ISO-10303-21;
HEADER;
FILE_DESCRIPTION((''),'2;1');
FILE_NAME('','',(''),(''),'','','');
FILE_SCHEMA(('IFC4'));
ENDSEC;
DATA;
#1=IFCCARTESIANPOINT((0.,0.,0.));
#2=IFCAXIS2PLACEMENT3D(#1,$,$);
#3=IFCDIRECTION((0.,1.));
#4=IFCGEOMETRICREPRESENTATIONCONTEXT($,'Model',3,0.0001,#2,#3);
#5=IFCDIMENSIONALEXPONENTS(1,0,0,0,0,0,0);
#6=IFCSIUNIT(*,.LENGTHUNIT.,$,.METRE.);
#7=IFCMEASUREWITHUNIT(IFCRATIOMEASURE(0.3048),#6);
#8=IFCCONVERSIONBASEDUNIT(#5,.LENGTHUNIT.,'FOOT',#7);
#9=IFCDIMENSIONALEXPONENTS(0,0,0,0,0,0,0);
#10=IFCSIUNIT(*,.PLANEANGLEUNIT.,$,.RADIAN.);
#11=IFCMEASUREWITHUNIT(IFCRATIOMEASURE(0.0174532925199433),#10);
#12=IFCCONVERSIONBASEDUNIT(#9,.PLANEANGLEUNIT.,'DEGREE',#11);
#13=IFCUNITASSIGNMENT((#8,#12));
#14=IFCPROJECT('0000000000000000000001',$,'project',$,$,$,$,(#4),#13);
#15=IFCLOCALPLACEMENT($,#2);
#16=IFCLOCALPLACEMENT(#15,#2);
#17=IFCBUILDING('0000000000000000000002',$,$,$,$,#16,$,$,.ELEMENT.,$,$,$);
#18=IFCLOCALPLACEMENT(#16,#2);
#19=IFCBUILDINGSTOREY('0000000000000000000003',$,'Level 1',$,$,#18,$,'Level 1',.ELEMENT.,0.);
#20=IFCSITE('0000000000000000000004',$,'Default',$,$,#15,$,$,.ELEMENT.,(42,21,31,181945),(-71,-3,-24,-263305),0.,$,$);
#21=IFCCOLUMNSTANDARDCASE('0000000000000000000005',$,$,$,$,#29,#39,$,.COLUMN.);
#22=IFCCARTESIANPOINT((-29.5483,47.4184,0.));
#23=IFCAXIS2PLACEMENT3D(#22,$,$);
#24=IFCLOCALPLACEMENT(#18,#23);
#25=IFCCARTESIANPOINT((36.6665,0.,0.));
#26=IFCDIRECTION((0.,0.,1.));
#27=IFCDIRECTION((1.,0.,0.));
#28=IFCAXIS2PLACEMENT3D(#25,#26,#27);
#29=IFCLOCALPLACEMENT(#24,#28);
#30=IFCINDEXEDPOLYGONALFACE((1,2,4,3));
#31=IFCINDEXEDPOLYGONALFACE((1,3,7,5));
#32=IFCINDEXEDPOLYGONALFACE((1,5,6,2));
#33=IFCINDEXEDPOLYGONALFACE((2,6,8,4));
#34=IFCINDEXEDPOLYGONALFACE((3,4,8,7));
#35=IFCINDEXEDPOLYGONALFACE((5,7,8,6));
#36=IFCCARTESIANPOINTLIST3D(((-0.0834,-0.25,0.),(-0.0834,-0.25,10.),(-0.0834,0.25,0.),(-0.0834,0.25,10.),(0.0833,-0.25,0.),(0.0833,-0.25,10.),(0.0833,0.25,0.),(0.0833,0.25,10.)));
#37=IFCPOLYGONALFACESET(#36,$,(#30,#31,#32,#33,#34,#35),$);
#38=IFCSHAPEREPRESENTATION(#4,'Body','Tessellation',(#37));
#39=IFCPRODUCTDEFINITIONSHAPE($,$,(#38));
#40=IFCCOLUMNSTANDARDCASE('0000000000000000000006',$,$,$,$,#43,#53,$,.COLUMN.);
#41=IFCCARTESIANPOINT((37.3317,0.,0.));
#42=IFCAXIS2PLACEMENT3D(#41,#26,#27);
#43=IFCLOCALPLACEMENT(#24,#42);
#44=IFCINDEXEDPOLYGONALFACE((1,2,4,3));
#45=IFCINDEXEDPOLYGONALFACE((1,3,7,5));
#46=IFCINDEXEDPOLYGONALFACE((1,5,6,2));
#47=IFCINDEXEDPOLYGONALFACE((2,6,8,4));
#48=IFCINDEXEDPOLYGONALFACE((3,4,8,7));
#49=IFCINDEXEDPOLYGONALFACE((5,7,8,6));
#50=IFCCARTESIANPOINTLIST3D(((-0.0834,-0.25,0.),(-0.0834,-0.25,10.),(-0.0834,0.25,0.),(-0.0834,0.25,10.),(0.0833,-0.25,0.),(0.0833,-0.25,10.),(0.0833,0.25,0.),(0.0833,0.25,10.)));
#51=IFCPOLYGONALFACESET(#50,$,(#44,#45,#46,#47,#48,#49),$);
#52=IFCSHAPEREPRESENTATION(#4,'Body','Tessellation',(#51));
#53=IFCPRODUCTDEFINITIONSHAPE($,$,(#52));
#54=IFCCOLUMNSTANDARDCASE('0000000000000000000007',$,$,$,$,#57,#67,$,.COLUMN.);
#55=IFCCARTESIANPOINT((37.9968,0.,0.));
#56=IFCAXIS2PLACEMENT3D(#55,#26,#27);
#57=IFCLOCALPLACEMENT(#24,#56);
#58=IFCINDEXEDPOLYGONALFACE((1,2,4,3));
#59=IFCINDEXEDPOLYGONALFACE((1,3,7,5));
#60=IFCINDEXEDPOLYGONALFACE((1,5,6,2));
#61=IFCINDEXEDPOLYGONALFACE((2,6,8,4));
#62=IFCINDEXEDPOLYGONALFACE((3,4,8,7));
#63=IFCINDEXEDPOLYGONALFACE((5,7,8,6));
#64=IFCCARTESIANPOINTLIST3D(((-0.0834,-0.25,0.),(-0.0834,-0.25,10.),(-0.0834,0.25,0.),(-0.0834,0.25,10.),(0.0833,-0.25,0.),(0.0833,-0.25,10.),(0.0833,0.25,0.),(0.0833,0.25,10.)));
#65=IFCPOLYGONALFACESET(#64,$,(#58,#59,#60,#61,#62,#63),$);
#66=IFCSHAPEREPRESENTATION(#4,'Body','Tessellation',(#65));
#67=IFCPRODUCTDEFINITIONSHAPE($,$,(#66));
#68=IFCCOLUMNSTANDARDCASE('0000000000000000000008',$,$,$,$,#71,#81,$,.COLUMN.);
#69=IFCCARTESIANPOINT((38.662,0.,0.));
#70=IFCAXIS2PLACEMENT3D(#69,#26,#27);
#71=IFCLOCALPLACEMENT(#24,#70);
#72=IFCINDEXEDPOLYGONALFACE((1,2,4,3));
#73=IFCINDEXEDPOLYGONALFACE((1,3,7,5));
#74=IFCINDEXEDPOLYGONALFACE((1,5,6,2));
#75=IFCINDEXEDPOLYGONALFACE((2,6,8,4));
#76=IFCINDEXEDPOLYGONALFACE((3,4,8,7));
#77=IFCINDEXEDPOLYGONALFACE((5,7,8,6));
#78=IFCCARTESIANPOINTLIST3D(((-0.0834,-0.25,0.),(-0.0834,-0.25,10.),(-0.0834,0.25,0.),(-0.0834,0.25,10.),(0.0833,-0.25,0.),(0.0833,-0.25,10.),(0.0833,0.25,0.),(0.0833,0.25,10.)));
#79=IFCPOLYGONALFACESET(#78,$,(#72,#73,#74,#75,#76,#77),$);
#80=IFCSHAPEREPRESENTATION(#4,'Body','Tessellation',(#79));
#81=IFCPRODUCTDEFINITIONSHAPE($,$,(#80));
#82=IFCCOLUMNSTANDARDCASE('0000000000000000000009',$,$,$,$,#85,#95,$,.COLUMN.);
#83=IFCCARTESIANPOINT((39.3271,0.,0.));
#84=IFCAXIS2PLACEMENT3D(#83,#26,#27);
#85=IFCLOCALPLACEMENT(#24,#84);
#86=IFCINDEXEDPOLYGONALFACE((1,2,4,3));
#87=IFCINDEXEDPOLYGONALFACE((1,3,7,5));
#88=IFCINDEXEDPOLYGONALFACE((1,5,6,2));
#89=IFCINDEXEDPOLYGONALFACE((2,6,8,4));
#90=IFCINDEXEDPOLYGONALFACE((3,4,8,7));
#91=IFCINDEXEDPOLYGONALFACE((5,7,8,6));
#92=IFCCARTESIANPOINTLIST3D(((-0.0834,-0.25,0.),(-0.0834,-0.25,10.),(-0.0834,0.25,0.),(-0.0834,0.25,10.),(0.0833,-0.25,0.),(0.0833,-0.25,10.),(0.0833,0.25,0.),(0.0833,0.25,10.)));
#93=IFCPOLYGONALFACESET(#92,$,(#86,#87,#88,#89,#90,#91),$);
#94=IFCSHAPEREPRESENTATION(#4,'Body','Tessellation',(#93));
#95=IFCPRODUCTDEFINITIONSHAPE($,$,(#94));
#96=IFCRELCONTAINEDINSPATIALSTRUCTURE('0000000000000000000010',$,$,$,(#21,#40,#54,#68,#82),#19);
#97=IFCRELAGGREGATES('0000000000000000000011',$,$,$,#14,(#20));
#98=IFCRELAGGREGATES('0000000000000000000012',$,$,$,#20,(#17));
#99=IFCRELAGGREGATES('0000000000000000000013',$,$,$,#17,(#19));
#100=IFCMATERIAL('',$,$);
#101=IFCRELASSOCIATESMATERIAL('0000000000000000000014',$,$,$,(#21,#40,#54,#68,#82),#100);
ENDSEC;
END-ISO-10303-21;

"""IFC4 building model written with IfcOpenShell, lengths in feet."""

from ifc_helpers import new_model, entity, si_unit, converted_unit, direction, frame, origin, place, context, project, spatial, rectangle, extrude, material, element, save


model = new_model("IFC4")

# Units and contexts
model_context = context("Model", 3, precision=0.0001, world=origin(), true_north=direction((0.0, 1.0)))
ifc_project = project(units=[converted_unit("LENGTHUNIT", "FOOT", entity("IfcRatioMeasure", 0.3048), si_unit("LENGTHUNIT", "METRE"), dimensions=[1, 0, 0, 0, 0, 0, 0]), converted_unit("PLANEANGLEUNIT", "DEGREE", entity("IfcRatioMeasure", 0.0174532925199433), si_unit("PLANEANGLEUNIT", "RADIAN"), dimensions=[0, 0, 0, 0, 0, 0, 0])], contexts=[model_context])

# Site, building, storey
site_placement = place(None, origin())
site = spatial("IfcSite", under=ifc_project, at=site_placement, Name="Default", CompositionType="ELEMENT", RefLatitude=(42, 21, 31, 181945), RefLongitude=(-71, -3, -24, -263305), RefElevation=0.0)
building_placement = place(site_placement, origin())
building = spatial("IfcBuilding", under=site, at=building_placement, CompositionType="ELEMENT")
storey_placement = place(building_placement, origin())
storey = spatial("IfcBuildingStorey", under=building, at=storey_placement, Name="Level 1", LongName="Level 1", CompositionType="ELEMENT", Elevation=0.0)

# Columns
ifc_material = material(Name="")
placement = place(storey_placement, frame((-29.5483, 47.4184, 0.0)))
for number, where, z_axis, x_axis in (
    (1, (36.6665, 0.0, 0.0), (0.0, 0.0, 1.0), (1.0, 0.0, 0.0)),
    (2, (37.3317, 0.0, 0.0), (0.0, 0.0, 1.0), (1.0, 0.0, 0.0)),
    (3, (37.9968, 0.0, 0.0), (0.0, 0.0, 1.0), (1.0, 0.0, 0.0)),
    (4, (38.662, 0.0, 0.0), (0.0, 0.0, 1.0), (1.0, 0.0, 0.0)),
    (5, (39.3271, 0.0, 0.0), (0.0, 0.0, 1.0), (1.0, 0.0, 0.0)),
):
    element("IfcColumnStandardCase", number, at=place(placement, frame(where, z_axis=z_axis, x_axis=x_axis)), inside=storey, material=ifc_material, PredefinedType="COLUMN", context=model_context, shape_type="SweptSolid", body=[
        extrude(rectangle(XDim=0.1667, YDim=0.5), origin(), (0.0, 0.0, 1.0), 10.0),
    ])

save(model, "model.ifc")
